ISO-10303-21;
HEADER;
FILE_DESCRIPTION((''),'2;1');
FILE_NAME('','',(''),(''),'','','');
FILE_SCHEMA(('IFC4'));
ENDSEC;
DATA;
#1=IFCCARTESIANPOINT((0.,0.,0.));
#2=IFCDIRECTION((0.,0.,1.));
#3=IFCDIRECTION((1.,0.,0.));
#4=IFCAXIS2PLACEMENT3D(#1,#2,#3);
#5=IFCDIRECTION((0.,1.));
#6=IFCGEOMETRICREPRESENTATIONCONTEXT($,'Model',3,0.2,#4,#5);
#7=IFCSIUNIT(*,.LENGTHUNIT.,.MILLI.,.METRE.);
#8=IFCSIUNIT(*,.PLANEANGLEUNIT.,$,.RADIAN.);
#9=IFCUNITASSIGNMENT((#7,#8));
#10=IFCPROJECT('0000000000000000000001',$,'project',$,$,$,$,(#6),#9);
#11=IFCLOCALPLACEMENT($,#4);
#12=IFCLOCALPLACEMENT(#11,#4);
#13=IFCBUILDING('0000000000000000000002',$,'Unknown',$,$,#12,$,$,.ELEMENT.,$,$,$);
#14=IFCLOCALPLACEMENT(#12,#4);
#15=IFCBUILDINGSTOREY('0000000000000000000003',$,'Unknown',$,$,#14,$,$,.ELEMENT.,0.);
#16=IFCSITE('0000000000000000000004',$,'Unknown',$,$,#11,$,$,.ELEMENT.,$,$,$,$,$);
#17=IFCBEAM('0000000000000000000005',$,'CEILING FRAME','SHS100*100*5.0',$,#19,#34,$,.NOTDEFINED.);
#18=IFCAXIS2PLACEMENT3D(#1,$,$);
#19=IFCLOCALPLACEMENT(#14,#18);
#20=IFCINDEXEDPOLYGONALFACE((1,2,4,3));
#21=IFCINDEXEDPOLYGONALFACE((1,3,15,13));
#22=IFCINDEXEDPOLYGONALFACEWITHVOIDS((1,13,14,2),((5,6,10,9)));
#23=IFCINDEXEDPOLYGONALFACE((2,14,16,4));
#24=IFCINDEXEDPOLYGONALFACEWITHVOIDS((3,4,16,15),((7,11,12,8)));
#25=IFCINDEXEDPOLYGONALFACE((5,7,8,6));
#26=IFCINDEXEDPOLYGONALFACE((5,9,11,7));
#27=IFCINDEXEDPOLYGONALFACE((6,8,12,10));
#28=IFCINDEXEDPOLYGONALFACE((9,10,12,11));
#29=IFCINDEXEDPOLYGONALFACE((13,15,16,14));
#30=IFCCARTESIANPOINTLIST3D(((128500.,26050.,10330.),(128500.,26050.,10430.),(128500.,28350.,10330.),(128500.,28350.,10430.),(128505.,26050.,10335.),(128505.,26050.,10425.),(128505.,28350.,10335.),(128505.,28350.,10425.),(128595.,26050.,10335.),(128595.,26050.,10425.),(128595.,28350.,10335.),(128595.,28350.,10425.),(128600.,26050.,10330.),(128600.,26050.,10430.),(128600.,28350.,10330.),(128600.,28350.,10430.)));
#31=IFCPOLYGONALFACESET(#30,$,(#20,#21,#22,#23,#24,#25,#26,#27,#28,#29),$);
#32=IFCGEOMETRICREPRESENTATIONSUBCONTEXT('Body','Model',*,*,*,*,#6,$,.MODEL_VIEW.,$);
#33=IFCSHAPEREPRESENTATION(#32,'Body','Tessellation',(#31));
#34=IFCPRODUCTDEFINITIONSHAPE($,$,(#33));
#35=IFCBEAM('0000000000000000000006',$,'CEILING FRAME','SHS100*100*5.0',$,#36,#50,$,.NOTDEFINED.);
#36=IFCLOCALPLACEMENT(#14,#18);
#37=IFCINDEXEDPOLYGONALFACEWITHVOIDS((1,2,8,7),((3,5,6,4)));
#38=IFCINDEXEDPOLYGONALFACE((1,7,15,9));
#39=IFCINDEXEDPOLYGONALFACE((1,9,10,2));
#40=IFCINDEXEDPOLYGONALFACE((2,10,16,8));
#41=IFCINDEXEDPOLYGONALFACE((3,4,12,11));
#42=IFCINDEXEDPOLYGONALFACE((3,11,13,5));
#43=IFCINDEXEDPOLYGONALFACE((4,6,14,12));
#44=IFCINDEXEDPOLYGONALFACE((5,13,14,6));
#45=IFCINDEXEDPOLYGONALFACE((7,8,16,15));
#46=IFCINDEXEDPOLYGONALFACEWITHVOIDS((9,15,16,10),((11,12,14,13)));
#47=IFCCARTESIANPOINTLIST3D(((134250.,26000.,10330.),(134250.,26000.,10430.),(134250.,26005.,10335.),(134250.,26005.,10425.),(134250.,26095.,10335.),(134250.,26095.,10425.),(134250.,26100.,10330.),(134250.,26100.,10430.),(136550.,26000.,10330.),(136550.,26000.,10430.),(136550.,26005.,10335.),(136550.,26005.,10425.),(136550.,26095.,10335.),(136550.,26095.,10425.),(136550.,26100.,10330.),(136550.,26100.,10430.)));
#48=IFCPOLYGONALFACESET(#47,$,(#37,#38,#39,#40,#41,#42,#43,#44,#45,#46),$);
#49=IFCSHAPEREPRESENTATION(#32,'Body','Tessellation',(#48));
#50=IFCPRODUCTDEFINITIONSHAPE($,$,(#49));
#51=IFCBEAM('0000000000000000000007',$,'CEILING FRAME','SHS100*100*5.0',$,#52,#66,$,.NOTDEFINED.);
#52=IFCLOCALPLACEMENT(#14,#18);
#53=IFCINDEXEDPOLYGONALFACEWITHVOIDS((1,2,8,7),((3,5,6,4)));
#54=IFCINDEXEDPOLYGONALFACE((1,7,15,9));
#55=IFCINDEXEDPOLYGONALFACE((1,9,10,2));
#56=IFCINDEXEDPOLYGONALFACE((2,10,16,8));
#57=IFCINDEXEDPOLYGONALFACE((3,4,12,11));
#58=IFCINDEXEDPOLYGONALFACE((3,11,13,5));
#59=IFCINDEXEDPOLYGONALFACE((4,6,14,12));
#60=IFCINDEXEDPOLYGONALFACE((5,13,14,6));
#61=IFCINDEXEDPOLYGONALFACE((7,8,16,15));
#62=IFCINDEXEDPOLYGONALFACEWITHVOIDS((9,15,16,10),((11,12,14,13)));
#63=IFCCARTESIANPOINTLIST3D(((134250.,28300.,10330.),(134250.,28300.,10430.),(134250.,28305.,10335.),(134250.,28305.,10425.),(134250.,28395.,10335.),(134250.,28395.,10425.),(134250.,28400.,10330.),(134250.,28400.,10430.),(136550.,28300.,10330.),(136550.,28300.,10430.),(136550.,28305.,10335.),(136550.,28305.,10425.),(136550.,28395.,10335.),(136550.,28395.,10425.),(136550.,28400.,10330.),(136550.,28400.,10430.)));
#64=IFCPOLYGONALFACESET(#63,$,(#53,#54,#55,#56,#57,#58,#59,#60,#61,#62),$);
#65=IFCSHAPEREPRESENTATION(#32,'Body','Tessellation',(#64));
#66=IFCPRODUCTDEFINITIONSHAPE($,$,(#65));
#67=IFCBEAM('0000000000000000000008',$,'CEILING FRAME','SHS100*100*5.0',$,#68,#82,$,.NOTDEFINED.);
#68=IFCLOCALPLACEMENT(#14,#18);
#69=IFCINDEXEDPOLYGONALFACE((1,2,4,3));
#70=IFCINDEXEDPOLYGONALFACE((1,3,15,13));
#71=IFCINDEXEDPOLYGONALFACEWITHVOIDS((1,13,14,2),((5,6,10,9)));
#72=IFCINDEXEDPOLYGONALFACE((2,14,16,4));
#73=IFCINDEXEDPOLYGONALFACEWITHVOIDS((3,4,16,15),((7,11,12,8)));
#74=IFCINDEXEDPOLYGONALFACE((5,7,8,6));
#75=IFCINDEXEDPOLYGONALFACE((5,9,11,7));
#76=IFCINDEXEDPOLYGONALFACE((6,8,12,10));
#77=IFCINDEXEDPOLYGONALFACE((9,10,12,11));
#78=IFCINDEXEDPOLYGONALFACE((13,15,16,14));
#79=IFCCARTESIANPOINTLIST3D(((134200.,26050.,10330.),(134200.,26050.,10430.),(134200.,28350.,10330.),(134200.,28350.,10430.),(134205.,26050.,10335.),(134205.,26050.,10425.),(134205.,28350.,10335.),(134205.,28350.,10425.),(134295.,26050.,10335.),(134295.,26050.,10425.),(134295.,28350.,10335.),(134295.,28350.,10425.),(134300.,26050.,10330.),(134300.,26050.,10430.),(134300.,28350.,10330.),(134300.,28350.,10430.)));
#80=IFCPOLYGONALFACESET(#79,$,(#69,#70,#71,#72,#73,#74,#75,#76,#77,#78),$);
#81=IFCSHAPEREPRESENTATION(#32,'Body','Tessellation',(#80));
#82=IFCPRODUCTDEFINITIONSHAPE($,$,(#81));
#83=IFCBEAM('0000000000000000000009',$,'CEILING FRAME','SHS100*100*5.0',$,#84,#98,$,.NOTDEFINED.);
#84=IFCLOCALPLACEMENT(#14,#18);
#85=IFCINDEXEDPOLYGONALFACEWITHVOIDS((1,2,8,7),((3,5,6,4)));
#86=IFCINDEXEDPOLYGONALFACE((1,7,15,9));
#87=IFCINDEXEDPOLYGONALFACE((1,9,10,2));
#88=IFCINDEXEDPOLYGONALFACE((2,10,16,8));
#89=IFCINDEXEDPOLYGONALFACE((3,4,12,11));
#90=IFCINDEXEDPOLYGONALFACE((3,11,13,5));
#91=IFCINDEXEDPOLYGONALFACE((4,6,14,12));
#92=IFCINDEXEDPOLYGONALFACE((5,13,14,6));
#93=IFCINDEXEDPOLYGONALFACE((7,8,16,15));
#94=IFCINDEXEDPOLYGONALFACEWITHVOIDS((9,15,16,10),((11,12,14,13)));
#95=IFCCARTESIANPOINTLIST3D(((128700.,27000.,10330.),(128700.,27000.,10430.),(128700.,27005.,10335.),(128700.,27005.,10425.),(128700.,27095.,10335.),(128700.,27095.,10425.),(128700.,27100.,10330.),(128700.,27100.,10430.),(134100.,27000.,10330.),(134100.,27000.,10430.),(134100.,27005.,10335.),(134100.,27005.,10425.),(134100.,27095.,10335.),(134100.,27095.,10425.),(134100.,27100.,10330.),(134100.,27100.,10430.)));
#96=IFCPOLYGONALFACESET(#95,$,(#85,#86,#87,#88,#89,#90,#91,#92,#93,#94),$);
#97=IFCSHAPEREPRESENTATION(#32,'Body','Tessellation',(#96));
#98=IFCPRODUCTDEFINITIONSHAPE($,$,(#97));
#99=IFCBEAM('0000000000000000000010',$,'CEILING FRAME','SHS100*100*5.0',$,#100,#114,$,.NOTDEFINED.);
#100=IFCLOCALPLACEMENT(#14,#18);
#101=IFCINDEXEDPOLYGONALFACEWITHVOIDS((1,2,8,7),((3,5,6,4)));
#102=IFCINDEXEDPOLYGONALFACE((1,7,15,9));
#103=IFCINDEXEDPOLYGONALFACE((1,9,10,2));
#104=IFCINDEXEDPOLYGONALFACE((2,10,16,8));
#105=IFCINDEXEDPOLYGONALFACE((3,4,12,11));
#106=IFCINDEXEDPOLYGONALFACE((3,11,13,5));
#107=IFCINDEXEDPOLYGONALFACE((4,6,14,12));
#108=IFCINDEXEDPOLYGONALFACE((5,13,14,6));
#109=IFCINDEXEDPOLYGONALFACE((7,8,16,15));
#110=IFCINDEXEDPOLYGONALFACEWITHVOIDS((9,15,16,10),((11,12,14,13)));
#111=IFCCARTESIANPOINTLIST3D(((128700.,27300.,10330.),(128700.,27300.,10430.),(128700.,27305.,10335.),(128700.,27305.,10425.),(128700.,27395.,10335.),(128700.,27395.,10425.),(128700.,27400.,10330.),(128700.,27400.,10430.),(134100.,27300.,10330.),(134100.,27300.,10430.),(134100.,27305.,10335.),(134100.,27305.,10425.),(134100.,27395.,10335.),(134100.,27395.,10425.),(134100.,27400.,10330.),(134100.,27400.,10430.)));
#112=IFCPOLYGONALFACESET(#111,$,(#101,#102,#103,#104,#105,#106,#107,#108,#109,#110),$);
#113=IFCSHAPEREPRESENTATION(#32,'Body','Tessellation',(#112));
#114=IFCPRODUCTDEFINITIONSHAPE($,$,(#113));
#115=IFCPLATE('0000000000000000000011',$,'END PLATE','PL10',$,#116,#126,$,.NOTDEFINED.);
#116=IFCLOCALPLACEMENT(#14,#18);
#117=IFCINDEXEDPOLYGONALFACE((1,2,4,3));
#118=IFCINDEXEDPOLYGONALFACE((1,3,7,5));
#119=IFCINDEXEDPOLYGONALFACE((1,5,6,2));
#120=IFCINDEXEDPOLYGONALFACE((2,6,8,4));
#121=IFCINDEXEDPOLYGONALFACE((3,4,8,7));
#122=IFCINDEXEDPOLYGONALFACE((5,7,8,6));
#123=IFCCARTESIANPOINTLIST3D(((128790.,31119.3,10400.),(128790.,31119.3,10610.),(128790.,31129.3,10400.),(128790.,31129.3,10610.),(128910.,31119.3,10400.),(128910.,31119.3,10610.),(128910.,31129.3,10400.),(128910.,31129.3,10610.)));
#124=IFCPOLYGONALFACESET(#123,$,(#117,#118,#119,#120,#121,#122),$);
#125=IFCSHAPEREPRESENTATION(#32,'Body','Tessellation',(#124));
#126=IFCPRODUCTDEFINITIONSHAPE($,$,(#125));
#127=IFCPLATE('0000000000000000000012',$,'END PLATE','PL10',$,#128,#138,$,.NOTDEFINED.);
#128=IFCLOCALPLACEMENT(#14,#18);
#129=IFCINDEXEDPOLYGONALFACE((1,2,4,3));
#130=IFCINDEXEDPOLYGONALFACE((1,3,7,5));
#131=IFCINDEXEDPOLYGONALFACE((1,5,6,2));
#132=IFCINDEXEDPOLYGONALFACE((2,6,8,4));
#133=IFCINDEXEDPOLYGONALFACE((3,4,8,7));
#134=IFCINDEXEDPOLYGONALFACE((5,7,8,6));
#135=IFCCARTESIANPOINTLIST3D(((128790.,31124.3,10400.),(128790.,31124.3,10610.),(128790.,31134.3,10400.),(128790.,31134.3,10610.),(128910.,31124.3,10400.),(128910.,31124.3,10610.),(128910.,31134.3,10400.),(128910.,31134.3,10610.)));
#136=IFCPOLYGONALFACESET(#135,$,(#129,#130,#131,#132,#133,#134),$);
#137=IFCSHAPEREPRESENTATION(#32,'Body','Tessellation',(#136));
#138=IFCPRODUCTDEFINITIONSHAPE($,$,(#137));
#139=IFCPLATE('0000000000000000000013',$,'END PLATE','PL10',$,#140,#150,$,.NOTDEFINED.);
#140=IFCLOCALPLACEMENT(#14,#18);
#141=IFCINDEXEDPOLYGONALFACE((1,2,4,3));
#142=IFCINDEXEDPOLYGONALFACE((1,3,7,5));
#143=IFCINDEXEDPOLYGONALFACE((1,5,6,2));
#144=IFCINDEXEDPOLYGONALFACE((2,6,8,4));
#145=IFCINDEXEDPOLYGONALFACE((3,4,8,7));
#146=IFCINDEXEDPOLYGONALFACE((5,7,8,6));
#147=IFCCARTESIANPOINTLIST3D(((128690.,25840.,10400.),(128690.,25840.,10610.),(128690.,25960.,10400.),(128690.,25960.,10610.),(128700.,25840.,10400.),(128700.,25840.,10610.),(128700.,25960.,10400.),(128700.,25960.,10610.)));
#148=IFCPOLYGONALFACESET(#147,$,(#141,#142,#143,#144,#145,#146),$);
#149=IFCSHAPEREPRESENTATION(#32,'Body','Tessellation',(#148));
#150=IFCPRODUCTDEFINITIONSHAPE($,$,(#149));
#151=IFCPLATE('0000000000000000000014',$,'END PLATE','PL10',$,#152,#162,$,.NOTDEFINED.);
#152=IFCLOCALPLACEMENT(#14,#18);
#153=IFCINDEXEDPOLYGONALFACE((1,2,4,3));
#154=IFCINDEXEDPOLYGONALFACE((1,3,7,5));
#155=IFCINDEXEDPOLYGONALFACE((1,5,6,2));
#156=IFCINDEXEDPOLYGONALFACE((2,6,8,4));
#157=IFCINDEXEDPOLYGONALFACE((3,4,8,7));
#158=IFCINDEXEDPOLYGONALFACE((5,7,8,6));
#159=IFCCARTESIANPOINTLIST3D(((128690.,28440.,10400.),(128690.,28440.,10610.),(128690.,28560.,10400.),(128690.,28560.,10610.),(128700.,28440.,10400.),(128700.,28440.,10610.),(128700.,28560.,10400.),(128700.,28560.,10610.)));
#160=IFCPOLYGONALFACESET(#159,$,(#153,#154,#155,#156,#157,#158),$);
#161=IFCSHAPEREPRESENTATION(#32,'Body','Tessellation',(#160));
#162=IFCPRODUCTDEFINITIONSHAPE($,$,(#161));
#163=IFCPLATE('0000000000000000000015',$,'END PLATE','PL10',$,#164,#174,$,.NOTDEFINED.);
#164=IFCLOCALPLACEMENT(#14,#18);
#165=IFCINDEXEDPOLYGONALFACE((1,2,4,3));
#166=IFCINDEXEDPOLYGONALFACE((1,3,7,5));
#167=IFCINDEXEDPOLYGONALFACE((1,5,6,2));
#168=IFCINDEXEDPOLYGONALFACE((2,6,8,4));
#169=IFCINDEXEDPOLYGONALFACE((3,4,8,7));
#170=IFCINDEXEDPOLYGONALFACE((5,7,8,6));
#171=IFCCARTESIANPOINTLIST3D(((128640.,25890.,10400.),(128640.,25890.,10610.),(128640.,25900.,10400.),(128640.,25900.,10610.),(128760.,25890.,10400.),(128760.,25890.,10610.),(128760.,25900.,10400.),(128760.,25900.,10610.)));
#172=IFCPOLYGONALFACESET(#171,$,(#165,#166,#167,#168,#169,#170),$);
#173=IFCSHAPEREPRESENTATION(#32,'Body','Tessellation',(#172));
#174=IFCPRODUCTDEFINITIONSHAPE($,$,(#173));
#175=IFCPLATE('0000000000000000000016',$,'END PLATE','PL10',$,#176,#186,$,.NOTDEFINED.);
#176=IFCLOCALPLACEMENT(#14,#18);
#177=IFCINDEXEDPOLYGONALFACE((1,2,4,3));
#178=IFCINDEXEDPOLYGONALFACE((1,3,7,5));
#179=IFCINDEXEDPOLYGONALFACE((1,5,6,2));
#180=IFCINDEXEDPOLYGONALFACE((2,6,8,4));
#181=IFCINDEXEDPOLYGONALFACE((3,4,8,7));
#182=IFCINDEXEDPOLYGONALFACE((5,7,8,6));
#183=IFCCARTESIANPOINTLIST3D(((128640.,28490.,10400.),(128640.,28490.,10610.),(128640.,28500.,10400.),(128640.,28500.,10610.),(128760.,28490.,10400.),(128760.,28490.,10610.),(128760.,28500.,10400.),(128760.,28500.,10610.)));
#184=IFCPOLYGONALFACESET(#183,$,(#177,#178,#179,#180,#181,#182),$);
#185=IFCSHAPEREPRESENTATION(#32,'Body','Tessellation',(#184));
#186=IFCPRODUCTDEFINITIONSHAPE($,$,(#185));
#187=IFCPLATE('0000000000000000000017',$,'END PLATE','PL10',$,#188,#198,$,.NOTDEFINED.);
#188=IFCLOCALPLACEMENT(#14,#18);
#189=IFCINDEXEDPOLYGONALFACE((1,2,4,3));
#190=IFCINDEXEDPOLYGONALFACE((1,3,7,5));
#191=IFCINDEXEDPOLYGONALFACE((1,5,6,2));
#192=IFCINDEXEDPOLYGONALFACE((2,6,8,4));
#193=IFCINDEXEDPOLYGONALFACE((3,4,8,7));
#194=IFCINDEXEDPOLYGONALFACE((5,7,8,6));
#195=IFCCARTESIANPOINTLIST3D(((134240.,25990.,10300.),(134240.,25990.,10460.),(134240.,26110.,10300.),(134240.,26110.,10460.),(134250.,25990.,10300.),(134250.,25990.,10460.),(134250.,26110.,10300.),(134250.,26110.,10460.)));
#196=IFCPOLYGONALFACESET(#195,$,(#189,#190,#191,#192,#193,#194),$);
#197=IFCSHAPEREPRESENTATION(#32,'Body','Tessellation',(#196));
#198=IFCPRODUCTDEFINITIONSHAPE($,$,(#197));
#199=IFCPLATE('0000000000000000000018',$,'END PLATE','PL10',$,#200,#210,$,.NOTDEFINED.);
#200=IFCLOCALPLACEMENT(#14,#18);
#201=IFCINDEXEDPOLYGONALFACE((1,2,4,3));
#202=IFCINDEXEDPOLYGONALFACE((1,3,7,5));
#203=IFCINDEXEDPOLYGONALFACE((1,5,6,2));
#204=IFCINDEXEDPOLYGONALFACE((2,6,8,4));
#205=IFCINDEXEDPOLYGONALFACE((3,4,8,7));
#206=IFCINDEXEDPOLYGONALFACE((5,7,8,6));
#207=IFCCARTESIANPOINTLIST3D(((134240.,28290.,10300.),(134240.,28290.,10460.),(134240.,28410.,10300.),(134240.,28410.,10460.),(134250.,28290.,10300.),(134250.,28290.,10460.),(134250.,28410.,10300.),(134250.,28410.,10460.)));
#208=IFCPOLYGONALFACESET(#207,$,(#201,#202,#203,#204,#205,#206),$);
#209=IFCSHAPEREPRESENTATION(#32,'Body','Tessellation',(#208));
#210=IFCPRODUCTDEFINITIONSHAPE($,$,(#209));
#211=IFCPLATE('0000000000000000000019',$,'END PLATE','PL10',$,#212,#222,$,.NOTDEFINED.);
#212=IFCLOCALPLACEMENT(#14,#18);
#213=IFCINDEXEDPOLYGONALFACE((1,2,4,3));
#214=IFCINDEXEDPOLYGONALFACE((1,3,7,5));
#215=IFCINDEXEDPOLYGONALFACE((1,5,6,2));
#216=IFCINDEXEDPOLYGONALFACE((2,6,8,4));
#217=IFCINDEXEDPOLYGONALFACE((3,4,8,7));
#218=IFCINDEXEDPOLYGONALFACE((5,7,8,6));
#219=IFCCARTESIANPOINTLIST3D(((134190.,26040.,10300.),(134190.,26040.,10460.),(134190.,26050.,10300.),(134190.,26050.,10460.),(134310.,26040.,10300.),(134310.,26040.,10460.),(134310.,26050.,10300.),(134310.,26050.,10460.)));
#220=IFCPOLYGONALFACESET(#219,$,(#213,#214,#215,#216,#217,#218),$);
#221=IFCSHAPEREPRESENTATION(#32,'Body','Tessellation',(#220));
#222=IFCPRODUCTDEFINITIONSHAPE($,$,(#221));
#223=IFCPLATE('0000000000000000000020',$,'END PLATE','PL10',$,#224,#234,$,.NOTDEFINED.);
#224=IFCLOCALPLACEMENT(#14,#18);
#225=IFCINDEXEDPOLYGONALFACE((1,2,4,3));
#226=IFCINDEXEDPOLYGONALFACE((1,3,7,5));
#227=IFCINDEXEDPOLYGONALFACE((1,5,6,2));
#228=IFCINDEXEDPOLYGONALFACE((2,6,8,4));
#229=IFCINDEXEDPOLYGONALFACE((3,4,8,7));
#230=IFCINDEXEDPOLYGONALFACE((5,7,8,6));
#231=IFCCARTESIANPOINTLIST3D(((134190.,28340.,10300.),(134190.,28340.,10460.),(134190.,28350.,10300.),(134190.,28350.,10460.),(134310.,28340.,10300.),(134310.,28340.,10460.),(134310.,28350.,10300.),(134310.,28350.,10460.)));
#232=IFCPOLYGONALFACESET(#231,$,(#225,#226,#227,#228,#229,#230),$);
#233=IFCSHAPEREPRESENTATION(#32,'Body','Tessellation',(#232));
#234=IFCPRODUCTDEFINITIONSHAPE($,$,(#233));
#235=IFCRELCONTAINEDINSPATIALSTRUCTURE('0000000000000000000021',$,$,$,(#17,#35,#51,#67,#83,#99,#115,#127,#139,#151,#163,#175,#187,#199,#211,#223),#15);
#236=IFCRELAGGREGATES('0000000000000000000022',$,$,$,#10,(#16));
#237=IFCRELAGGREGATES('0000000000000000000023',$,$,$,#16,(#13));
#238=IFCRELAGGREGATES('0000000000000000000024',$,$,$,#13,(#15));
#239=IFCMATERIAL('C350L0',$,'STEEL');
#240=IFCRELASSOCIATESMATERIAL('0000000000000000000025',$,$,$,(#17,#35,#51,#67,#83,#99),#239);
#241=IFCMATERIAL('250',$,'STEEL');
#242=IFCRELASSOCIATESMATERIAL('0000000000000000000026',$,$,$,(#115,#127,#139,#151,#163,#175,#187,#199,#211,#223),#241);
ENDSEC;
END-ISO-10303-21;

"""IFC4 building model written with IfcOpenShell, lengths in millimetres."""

from ifc_helpers import new_model, si_unit, direction, frame, origin_with_axes, place, context, subcontext, project, spatial, line, indexed_curve, outline, extrude, material, element, save


model = new_model("IFC4")

# Units and contexts
model_context = context("Model", 3, precision=0.2, world=origin_with_axes(), true_north=direction((0.0, 1.0)))
body_context = subcontext(model_context, "Body", "Model", "MODEL_VIEW")
ifc_project = project(units=[si_unit("LENGTHUNIT", "METRE", prefix="MILLI"), si_unit("PLANEANGLEUNIT", "RADIAN")], contexts=[model_context])

# Site, building, storey
site_placement = place(None, origin_with_axes())
site = spatial("IfcSite", under=ifc_project, at=site_placement, Name="Unknown", CompositionType="ELEMENT")
building_placement = place(site_placement, origin_with_axes())
building = spatial("IfcBuilding", under=site, at=building_placement, Name="Unknown", CompositionType="ELEMENT")
storey_placement = place(building_placement, origin_with_axes())
storey = spatial("IfcBuildingStorey", under=building, at=storey_placement, Name="Unknown", CompositionType="ELEMENT", Elevation=0.0)

# Beams
ifc_material_1 = material(Name="C350L0", Category="STEEL")
for number, where, z_axis, x_axis, name in (
    (1, (128550.0, 26050.0, 10380.0), (0.0, 0.0, 1.0), (0.0, 1.0, 0.0), "CEILING FRAME"),
    (2, (134250.0, 26050.0, 10380.0), (0.0, 0.0, 1.0), (1.0, 0.0, 0.0), "CEILING FRAME"),
    (3, (134250.0, 28350.0, 10380.0), (0.0, 0.0, 1.0), (1.0, 0.0, 0.0), "CEILING FRAME"),
    (4, (134250.0, 26050.0, 10380.0), (0.0, 0.0, 1.0), (0.0, 1.0, 0.0), "CEILING FRAME"),
):
    element("IfcBeam", number, at=place(storey_placement, frame(where, z_axis=z_axis, x_axis=x_axis)), inside=storey, material=ifc_material_1, Name=name, Description="SHS100*100*5.0", PredefinedType="NOTDEFINED", context=body_context, shape_type="SolidModel", body=[
        extrude(outline(indexed_curve([(-50.0, -50.0), (50.0, -50.0), (50.0, 50.0), (-50.0, 50.0)], segments=[line(1, 2, 3, 4, 1)]), holes=[indexed_curve([(-45.0, -45.0), (-45.0, 45.0), (45.0, 45.0), (45.0, -45.0)], segments=[line(1, 2, 3, 4, 1)])]), frame((0.0, 0.0, 0.0), z_axis=(-1.0, 0.0, 0.0), x_axis=(0.0, 0.0, 1.0)), (0.0, 0.0, -1.0), 2300.0),
    ])
for number, where, z_axis, x_axis, name in (
    (5, (128700.0, 27050.0, 10380.0), (0.0, 0.0, 1.0), (1.0, 0.0, 0.0), "CEILING FRAME"),
    (6, (128700.0, 27350.0, 10380.0), (0.0, 0.0, 1.0), (1.0, 0.0, 0.0), "CEILING FRAME"),
):
    element("IfcBeam", number, at=place(storey_placement, frame(where, z_axis=z_axis, x_axis=x_axis)), inside=storey, material=ifc_material_1, Name=name, Description="SHS100*100*5.0", PredefinedType="NOTDEFINED", context=body_context, shape_type="SolidModel", body=[
        extrude(outline(indexed_curve([(-50.0, -50.0), (50.0, -50.0), (50.0, 50.0), (-50.0, 50.0)], segments=[line(1, 2, 3, 4, 1)]), holes=[indexed_curve([(-45.0, -45.0), (-45.0, 45.0), (45.0, 45.0), (45.0, -45.0)], segments=[line(1, 2, 3, 4, 1)])]), frame((0.0, 0.0, 0.0), z_axis=(-1.0, 0.0, 0.0), x_axis=(0.0, 0.0, 1.0)), (0.0, 0.0, -1.0), 5400.0),
    ])

# Plates
ifc_material_2 = material(Name="250", Category="STEEL")
for number, where, z_axis, x_axis, name in (
    (7, (128790.0, 31124.3, 10400.0), (0.0, -1.0, 0.0), (1.0, 0.0, 0.0), "END PLATE"),
    (8, (128790.0, 31129.3, 10400.0), (0.0, -1.0, 0.0), (1.0, 0.0, 0.0), "END PLATE"),
    (9, (128695.0, 25960.0, 10400.0), (-1.0, 0.0, 0.0), (0.0, -1.0, 0.0), "END PLATE"),
    (10, (128695.0, 28560.0, 10400.0), (-1.0, 0.0, 0.0), (0.0, -1.0, 0.0), "END PLATE"),
    (11, (128640.0, 25895.0, 10400.0), (0.0, -1.0, 0.0), (1.0, 0.0, 0.0), "END PLATE"),
    (12, (128640.0, 28495.0, 10400.0), (0.0, -1.0, 0.0), (1.0, 0.0, 0.0), "END PLATE"),
):
    element("IfcPlate", number, at=place(storey_placement, frame(where, z_axis=z_axis, x_axis=x_axis)), inside=storey, material=ifc_material_2, Name=name, Description="PL10", PredefinedType="NOTDEFINED", context=body_context, shape_type="SolidModel", body=[
        extrude(outline(indexed_curve([(0.0, 0.0), (120.0, 0.0), (120.0, 210.0), (0.0, 210.0)], segments=[line(1, 2, 3, 4, 1)])), frame((0.0, 0.0, 5.0), z_axis=(0.0, 0.0, 1.0), x_axis=(1.0, 0.0, 0.0)), (0.0, 0.0, -1.0), 10.0),
    ])
for number, where, z_axis, x_axis, name in (
    (13, (134245.0, 26110.0, 10300.0), (-1.0, 0.0, 0.0), (0.0, -1.0, 0.0), "END PLATE"),
    (14, (134245.0, 28410.0, 10300.0), (-1.0, 0.0, 0.0), (0.0, -1.0, 0.0), "END PLATE"),
    (15, (134190.0, 26045.0, 10300.0), (0.0, -1.0, 0.0), (1.0, 0.0, 0.0), "END PLATE"),
    (16, (134190.0, 28345.0, 10300.0), (0.0, -1.0, 0.0), (1.0, 0.0, 0.0), "END PLATE"),
):
    element("IfcPlate", number, at=place(storey_placement, frame(where, z_axis=z_axis, x_axis=x_axis)), inside=storey, material=ifc_material_2, Name=name, Description="PL10", PredefinedType="NOTDEFINED", context=body_context, shape_type="SolidModel", body=[
        extrude(outline(indexed_curve([(0.0, 0.0), (120.0, 0.0), (120.0, 160.0), (0.0, 160.0)], segments=[line(1, 2, 3, 4, 1)])), frame((0.0, 0.0, 5.0), z_axis=(0.0, 0.0, 1.0), x_axis=(1.0, 0.0, 0.0)), (0.0, 0.0, -1.0), 10.0),
    ])

save(model, "model.ifc")
